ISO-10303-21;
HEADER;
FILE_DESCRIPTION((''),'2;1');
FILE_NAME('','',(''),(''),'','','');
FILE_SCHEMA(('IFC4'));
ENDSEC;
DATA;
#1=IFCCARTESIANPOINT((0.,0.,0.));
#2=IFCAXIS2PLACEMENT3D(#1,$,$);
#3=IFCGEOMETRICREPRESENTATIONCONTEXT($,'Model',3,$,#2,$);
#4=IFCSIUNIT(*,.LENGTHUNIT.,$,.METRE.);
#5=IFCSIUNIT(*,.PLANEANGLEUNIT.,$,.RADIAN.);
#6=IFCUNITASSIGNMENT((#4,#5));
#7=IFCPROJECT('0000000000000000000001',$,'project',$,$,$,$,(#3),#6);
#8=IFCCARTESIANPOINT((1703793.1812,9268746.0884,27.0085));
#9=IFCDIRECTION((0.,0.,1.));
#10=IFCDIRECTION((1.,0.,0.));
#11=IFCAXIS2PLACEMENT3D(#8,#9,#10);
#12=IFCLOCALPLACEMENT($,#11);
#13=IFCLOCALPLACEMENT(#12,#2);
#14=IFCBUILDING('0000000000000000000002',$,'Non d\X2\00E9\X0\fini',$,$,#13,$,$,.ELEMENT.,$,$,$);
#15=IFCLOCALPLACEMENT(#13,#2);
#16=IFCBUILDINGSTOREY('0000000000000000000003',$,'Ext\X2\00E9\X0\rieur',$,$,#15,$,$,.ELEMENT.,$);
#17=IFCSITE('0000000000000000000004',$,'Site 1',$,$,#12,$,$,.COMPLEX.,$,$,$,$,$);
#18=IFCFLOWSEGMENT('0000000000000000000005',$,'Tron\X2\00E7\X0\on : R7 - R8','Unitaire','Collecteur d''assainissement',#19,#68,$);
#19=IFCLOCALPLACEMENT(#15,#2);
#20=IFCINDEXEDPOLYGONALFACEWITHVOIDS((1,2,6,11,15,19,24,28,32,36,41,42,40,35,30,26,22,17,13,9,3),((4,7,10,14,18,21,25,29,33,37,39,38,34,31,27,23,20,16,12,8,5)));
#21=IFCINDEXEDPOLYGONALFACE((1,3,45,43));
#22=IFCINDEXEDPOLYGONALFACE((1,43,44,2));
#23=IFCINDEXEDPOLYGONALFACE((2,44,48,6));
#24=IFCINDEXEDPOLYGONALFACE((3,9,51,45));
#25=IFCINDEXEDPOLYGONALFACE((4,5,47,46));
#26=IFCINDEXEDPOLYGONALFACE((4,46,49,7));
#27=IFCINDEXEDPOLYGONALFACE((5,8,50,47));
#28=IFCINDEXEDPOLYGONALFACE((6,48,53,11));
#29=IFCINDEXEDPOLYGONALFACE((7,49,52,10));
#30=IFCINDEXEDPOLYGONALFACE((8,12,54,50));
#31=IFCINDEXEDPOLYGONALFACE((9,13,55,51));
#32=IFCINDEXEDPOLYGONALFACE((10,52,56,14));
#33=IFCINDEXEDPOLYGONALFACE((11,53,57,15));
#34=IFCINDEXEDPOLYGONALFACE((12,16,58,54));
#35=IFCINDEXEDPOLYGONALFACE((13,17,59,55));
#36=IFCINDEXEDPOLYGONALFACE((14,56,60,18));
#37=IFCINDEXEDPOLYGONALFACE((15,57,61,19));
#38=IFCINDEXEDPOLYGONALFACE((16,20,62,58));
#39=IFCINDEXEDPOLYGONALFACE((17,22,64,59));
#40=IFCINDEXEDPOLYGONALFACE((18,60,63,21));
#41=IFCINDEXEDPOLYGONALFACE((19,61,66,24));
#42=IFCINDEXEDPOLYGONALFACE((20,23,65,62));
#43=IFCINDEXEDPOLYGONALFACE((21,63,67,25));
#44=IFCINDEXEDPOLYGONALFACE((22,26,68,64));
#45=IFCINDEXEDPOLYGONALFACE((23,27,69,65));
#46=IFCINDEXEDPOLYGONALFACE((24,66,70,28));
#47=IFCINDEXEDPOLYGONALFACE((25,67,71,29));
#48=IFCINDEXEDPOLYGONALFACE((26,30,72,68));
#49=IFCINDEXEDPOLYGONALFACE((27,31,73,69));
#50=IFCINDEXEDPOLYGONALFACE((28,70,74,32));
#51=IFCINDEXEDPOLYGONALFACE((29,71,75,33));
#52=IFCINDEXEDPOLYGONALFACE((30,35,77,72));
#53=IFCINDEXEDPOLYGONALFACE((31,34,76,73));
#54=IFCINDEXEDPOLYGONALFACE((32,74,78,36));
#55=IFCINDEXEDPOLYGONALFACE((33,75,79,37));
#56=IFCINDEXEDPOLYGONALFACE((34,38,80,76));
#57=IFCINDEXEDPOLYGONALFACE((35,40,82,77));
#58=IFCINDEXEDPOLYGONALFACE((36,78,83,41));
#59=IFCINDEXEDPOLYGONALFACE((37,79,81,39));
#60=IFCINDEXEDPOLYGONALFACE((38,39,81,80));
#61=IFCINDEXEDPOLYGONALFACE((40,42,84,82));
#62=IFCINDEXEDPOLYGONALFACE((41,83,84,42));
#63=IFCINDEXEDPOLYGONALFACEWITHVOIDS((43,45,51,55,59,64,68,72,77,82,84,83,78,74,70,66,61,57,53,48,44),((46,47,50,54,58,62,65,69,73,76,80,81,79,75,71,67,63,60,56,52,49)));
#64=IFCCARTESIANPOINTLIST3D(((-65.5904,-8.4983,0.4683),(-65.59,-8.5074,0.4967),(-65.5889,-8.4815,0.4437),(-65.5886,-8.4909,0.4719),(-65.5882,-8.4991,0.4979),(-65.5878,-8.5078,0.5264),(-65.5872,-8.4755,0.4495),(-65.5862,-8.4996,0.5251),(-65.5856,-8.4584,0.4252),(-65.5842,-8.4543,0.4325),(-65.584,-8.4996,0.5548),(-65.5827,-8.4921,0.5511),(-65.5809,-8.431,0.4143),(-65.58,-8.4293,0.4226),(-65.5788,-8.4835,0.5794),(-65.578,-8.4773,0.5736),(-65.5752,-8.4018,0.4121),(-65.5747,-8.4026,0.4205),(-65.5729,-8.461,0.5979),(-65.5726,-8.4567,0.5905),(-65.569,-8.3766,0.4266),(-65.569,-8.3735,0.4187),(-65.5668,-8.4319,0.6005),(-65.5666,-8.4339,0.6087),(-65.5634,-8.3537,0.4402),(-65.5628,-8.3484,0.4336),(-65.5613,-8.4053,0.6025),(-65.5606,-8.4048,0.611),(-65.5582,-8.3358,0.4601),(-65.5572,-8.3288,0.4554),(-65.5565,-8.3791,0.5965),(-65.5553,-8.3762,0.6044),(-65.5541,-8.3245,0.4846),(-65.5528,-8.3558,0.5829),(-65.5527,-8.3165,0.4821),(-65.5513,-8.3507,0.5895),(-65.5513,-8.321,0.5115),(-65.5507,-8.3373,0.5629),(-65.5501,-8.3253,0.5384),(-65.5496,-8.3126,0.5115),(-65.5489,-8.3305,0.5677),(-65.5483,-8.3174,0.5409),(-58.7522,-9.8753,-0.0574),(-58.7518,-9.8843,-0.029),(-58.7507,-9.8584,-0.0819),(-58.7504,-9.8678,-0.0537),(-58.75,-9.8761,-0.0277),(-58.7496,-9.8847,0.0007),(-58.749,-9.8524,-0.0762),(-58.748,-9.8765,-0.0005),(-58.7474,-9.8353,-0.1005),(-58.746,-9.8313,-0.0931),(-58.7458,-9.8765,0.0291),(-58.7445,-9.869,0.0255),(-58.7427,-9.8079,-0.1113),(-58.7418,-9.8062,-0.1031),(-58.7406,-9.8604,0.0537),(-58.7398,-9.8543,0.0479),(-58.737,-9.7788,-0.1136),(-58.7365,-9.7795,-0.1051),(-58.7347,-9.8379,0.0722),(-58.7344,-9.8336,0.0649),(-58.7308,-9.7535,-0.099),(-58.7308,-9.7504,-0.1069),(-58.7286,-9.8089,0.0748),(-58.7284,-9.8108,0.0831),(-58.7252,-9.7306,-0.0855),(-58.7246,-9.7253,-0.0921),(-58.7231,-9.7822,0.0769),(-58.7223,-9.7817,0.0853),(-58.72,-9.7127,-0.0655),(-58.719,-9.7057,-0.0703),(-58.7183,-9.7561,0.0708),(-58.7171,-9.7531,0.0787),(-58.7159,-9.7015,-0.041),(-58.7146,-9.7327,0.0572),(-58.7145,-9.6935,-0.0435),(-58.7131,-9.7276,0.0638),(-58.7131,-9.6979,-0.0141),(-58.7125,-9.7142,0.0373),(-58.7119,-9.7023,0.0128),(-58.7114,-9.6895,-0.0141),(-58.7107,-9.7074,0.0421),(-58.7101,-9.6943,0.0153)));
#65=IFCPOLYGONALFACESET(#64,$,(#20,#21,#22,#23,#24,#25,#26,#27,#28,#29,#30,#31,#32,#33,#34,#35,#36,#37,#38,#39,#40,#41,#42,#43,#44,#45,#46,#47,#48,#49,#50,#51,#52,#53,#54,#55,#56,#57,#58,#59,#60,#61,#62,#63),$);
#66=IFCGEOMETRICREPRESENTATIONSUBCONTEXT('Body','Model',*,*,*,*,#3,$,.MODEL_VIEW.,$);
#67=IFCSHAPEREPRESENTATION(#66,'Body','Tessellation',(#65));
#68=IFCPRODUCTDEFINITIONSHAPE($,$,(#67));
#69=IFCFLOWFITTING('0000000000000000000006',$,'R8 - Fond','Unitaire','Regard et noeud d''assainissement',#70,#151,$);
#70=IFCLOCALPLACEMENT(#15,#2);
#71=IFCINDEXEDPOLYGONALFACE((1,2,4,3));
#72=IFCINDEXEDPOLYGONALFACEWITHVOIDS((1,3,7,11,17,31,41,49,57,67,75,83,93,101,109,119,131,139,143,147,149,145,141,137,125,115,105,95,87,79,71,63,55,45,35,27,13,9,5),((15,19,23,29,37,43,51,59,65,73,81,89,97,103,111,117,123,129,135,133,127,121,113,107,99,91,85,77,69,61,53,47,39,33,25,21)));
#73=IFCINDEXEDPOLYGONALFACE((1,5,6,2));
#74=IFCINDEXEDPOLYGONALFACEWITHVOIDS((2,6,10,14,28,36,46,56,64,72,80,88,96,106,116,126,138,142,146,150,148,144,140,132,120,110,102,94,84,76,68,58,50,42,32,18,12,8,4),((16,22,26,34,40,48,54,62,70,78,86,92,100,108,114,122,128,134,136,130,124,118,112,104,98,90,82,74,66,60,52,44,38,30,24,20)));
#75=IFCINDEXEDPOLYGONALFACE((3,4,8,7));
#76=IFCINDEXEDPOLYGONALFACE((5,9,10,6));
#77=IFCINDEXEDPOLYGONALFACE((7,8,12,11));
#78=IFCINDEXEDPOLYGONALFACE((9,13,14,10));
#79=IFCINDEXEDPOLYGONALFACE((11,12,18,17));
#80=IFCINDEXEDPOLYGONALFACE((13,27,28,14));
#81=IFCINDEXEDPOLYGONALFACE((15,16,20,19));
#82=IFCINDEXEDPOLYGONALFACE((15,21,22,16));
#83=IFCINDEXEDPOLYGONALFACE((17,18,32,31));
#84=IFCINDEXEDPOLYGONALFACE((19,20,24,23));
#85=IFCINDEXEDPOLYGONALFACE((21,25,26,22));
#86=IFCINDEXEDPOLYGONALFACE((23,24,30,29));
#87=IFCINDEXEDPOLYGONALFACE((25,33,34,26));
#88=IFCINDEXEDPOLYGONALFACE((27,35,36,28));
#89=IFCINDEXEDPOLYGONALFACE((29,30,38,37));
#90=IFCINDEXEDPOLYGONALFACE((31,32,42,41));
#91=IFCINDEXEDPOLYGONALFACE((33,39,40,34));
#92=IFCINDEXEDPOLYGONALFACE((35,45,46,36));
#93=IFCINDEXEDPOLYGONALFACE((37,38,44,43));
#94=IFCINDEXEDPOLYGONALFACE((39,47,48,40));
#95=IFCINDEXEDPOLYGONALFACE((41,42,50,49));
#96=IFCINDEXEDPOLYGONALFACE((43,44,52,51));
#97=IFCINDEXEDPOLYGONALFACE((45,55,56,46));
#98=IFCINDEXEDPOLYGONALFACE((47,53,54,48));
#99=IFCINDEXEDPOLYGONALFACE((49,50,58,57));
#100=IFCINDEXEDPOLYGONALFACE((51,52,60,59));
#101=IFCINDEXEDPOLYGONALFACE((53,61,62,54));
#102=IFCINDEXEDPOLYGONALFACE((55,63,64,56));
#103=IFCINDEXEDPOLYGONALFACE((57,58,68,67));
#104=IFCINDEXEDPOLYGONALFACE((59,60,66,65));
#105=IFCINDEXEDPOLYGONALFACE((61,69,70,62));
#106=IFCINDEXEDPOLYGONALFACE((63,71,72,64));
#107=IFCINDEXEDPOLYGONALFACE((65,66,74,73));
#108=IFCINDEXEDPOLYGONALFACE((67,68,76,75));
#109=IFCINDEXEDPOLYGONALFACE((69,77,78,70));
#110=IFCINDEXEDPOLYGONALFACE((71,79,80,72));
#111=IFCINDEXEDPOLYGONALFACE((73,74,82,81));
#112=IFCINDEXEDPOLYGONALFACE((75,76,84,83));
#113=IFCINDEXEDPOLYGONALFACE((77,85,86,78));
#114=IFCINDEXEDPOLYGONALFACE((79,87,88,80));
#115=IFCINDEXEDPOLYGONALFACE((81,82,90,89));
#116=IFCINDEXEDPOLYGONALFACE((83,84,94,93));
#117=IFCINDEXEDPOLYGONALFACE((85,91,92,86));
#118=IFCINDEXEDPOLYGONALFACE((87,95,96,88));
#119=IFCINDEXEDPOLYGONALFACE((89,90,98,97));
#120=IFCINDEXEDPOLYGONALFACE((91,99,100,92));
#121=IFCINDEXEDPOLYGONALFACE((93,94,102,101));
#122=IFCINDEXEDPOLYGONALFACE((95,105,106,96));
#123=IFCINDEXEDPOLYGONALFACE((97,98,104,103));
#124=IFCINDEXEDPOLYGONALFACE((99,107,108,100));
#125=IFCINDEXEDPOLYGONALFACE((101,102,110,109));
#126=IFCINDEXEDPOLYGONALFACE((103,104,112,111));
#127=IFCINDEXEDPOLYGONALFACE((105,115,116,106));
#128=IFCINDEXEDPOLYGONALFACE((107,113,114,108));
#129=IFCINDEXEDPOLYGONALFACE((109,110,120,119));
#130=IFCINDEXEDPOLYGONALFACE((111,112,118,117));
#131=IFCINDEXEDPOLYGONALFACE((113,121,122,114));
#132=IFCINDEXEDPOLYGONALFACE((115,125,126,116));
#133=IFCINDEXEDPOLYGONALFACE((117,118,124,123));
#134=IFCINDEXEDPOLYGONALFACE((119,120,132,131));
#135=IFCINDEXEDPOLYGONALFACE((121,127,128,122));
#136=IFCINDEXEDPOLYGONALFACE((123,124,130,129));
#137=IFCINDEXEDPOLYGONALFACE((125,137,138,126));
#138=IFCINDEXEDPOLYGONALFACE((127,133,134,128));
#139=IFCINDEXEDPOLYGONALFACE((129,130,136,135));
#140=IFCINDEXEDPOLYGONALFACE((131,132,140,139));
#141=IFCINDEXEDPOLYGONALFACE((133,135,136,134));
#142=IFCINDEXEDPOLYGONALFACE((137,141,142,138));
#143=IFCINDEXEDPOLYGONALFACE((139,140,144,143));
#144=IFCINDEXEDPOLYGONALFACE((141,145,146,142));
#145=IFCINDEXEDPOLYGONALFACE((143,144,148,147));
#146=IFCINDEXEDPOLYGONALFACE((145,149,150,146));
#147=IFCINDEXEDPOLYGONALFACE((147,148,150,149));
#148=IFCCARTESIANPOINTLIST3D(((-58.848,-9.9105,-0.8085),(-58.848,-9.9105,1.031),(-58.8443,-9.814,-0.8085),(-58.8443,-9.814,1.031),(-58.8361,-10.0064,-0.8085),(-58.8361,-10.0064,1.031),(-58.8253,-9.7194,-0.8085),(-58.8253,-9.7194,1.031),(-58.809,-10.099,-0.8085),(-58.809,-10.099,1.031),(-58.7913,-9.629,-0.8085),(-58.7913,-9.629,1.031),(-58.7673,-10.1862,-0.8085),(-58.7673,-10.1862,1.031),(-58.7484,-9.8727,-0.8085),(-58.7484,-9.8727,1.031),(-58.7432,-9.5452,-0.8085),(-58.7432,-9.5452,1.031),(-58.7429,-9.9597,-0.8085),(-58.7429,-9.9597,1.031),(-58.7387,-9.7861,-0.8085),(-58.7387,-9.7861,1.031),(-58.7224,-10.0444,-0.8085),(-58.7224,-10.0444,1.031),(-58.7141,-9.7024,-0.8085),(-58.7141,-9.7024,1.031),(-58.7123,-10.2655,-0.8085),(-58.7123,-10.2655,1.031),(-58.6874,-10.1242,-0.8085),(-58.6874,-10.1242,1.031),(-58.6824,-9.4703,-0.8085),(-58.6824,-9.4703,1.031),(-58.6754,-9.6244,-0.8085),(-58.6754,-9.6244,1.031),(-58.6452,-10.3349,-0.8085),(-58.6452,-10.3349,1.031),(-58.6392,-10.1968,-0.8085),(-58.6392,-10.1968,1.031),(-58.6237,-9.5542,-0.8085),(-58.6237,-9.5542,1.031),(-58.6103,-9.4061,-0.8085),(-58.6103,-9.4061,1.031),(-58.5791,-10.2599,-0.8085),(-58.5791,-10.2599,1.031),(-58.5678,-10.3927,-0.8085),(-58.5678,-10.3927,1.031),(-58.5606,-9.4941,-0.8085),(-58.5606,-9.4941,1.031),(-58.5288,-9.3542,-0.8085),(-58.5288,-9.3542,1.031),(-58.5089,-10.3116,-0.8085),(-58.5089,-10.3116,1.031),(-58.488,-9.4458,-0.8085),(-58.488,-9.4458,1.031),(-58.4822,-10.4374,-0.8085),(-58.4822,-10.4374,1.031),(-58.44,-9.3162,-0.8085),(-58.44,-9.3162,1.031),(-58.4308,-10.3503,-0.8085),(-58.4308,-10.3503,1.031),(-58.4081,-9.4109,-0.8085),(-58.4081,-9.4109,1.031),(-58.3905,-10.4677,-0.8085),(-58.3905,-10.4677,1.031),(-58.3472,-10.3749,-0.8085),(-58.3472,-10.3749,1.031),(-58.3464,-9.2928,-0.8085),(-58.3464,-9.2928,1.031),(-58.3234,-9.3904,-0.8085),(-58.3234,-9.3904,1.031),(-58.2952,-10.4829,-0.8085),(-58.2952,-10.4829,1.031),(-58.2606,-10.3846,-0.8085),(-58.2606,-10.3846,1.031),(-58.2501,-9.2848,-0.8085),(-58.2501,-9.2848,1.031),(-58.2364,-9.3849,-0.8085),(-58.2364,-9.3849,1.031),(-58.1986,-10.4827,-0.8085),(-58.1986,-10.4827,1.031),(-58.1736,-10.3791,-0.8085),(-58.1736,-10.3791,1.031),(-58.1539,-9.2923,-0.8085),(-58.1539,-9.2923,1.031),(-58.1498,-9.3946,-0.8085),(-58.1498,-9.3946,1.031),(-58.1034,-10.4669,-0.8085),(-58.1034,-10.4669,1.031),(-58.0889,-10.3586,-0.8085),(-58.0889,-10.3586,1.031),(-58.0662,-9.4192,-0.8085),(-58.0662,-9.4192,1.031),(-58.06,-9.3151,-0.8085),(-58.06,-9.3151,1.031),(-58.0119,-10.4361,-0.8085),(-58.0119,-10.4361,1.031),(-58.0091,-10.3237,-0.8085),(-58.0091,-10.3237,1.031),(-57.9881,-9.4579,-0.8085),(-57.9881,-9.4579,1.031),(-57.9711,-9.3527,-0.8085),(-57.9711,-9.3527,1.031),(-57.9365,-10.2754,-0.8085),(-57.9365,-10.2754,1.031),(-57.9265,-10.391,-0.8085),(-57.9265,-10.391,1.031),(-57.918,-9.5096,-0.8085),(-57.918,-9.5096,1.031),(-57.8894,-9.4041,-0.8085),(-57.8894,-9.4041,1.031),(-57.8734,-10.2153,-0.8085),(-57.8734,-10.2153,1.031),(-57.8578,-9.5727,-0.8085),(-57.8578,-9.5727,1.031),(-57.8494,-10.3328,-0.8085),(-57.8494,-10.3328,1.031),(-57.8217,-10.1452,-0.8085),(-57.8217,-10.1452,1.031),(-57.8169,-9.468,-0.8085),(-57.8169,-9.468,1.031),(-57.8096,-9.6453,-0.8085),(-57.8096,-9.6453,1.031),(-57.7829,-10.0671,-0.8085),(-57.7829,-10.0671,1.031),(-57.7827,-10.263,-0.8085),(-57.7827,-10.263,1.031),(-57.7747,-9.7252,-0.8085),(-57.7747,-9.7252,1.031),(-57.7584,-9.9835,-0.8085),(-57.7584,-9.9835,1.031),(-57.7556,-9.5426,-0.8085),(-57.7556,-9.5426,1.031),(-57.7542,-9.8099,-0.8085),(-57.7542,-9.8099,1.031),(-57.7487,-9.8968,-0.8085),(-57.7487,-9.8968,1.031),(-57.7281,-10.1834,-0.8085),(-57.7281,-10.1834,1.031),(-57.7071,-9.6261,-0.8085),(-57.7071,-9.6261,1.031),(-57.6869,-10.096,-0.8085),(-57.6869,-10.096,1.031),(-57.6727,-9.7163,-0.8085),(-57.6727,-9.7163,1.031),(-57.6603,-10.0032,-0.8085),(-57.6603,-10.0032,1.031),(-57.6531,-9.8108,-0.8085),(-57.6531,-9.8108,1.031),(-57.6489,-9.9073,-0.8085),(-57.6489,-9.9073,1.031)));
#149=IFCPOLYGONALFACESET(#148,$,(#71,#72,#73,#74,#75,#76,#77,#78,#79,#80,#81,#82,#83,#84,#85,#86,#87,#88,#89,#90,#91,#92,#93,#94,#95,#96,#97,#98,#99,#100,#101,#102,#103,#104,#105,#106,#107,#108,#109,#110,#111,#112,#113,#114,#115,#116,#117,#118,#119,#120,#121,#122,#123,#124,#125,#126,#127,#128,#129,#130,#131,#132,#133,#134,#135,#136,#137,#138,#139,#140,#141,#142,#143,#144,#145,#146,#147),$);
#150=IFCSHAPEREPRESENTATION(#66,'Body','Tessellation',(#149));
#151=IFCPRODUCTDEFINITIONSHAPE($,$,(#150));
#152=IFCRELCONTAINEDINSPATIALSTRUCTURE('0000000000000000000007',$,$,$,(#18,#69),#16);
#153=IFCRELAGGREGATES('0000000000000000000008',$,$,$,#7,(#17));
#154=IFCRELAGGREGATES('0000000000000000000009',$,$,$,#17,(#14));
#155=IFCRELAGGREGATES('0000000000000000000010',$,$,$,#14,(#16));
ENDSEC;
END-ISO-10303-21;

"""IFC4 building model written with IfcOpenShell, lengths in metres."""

from ifc_helpers import new_model, si_unit, frame, origin, origin_2d, place, context, subcontext, project, spatial, hollow_circle, extrude, element, save


model = new_model("IFC4")

# Units and contexts
model_context = context("Model", 3, world=origin())
body_context = subcontext(model_context, "Body", "Model", "MODEL_VIEW")
ifc_project = project(units=[si_unit("LENGTHUNIT", "METRE"), si_unit("PLANEANGLEUNIT", "RADIAN")], contexts=[model_context])

# Site, building, storey
site_placement = place(None, frame((1703793.1812, 9268746.0884, 27.0085), z_axis=(0.0, 0.0, 1.0), x_axis=(1.0, 0.0, 0.0)))
site = spatial("IfcSite", under=ifc_project, at=site_placement, Name="Site 1", CompositionType="COMPLEX")
building_placement = place(site_placement, origin())
building = spatial("IfcBuilding", under=site, at=building_placement, Name="Non défini", CompositionType="ELEMENT")
storey_placement = place(building_placement, origin())
storey = spatial("IfcBuildingStorey", under=building, at=storey_placement, Name="Extérieur", CompositionType="ELEMENT")

# Flow segment
flow_segment_1_placement = place(storey_placement, origin())
element("IfcFlowSegment", 1, at=flow_segment_1_placement, inside=storey, Name="Tronçon : R7 - R8", Description="Unitaire", ObjectType="Collecteur d'assainissement", context=body_context, shape_type="SweptSolid", body=[
    extrude(hollow_circle(Radius=0.1, WallThickness=0.0085, at=origin_2d()), frame((-65.5694, -8.4107, 0.5115), z_axis=(0.977552, -0.196838, -0.075143), x_axis=(0.197396, 0.980324, 0.0)), (0.0, 0.0, 1.0), 6.9952),
])

# Flow fitting
flow_fitting_1_placement = place(storey_placement, origin())
element("IfcFlowFitting", 2, at=flow_fitting_1_placement, inside=storey, Name="R8 - Fond", Description="Unitaire", ObjectType="Regard et noeud d'assainissement", context=body_context, shape_type="SweptSolid", body=[
    extrude(hollow_circle(Radius=0.6, WallThickness=0.1, at=origin_2d()), frame((-58.2485, -9.8848, -0.8085), z_axis=(0.0, 0.0, 1.0), x_axis=(0.980324, -0.197396, 0.0)), (0.0, 0.0, 1.0), 1.8395),
])

save(model, "model.ifc")
